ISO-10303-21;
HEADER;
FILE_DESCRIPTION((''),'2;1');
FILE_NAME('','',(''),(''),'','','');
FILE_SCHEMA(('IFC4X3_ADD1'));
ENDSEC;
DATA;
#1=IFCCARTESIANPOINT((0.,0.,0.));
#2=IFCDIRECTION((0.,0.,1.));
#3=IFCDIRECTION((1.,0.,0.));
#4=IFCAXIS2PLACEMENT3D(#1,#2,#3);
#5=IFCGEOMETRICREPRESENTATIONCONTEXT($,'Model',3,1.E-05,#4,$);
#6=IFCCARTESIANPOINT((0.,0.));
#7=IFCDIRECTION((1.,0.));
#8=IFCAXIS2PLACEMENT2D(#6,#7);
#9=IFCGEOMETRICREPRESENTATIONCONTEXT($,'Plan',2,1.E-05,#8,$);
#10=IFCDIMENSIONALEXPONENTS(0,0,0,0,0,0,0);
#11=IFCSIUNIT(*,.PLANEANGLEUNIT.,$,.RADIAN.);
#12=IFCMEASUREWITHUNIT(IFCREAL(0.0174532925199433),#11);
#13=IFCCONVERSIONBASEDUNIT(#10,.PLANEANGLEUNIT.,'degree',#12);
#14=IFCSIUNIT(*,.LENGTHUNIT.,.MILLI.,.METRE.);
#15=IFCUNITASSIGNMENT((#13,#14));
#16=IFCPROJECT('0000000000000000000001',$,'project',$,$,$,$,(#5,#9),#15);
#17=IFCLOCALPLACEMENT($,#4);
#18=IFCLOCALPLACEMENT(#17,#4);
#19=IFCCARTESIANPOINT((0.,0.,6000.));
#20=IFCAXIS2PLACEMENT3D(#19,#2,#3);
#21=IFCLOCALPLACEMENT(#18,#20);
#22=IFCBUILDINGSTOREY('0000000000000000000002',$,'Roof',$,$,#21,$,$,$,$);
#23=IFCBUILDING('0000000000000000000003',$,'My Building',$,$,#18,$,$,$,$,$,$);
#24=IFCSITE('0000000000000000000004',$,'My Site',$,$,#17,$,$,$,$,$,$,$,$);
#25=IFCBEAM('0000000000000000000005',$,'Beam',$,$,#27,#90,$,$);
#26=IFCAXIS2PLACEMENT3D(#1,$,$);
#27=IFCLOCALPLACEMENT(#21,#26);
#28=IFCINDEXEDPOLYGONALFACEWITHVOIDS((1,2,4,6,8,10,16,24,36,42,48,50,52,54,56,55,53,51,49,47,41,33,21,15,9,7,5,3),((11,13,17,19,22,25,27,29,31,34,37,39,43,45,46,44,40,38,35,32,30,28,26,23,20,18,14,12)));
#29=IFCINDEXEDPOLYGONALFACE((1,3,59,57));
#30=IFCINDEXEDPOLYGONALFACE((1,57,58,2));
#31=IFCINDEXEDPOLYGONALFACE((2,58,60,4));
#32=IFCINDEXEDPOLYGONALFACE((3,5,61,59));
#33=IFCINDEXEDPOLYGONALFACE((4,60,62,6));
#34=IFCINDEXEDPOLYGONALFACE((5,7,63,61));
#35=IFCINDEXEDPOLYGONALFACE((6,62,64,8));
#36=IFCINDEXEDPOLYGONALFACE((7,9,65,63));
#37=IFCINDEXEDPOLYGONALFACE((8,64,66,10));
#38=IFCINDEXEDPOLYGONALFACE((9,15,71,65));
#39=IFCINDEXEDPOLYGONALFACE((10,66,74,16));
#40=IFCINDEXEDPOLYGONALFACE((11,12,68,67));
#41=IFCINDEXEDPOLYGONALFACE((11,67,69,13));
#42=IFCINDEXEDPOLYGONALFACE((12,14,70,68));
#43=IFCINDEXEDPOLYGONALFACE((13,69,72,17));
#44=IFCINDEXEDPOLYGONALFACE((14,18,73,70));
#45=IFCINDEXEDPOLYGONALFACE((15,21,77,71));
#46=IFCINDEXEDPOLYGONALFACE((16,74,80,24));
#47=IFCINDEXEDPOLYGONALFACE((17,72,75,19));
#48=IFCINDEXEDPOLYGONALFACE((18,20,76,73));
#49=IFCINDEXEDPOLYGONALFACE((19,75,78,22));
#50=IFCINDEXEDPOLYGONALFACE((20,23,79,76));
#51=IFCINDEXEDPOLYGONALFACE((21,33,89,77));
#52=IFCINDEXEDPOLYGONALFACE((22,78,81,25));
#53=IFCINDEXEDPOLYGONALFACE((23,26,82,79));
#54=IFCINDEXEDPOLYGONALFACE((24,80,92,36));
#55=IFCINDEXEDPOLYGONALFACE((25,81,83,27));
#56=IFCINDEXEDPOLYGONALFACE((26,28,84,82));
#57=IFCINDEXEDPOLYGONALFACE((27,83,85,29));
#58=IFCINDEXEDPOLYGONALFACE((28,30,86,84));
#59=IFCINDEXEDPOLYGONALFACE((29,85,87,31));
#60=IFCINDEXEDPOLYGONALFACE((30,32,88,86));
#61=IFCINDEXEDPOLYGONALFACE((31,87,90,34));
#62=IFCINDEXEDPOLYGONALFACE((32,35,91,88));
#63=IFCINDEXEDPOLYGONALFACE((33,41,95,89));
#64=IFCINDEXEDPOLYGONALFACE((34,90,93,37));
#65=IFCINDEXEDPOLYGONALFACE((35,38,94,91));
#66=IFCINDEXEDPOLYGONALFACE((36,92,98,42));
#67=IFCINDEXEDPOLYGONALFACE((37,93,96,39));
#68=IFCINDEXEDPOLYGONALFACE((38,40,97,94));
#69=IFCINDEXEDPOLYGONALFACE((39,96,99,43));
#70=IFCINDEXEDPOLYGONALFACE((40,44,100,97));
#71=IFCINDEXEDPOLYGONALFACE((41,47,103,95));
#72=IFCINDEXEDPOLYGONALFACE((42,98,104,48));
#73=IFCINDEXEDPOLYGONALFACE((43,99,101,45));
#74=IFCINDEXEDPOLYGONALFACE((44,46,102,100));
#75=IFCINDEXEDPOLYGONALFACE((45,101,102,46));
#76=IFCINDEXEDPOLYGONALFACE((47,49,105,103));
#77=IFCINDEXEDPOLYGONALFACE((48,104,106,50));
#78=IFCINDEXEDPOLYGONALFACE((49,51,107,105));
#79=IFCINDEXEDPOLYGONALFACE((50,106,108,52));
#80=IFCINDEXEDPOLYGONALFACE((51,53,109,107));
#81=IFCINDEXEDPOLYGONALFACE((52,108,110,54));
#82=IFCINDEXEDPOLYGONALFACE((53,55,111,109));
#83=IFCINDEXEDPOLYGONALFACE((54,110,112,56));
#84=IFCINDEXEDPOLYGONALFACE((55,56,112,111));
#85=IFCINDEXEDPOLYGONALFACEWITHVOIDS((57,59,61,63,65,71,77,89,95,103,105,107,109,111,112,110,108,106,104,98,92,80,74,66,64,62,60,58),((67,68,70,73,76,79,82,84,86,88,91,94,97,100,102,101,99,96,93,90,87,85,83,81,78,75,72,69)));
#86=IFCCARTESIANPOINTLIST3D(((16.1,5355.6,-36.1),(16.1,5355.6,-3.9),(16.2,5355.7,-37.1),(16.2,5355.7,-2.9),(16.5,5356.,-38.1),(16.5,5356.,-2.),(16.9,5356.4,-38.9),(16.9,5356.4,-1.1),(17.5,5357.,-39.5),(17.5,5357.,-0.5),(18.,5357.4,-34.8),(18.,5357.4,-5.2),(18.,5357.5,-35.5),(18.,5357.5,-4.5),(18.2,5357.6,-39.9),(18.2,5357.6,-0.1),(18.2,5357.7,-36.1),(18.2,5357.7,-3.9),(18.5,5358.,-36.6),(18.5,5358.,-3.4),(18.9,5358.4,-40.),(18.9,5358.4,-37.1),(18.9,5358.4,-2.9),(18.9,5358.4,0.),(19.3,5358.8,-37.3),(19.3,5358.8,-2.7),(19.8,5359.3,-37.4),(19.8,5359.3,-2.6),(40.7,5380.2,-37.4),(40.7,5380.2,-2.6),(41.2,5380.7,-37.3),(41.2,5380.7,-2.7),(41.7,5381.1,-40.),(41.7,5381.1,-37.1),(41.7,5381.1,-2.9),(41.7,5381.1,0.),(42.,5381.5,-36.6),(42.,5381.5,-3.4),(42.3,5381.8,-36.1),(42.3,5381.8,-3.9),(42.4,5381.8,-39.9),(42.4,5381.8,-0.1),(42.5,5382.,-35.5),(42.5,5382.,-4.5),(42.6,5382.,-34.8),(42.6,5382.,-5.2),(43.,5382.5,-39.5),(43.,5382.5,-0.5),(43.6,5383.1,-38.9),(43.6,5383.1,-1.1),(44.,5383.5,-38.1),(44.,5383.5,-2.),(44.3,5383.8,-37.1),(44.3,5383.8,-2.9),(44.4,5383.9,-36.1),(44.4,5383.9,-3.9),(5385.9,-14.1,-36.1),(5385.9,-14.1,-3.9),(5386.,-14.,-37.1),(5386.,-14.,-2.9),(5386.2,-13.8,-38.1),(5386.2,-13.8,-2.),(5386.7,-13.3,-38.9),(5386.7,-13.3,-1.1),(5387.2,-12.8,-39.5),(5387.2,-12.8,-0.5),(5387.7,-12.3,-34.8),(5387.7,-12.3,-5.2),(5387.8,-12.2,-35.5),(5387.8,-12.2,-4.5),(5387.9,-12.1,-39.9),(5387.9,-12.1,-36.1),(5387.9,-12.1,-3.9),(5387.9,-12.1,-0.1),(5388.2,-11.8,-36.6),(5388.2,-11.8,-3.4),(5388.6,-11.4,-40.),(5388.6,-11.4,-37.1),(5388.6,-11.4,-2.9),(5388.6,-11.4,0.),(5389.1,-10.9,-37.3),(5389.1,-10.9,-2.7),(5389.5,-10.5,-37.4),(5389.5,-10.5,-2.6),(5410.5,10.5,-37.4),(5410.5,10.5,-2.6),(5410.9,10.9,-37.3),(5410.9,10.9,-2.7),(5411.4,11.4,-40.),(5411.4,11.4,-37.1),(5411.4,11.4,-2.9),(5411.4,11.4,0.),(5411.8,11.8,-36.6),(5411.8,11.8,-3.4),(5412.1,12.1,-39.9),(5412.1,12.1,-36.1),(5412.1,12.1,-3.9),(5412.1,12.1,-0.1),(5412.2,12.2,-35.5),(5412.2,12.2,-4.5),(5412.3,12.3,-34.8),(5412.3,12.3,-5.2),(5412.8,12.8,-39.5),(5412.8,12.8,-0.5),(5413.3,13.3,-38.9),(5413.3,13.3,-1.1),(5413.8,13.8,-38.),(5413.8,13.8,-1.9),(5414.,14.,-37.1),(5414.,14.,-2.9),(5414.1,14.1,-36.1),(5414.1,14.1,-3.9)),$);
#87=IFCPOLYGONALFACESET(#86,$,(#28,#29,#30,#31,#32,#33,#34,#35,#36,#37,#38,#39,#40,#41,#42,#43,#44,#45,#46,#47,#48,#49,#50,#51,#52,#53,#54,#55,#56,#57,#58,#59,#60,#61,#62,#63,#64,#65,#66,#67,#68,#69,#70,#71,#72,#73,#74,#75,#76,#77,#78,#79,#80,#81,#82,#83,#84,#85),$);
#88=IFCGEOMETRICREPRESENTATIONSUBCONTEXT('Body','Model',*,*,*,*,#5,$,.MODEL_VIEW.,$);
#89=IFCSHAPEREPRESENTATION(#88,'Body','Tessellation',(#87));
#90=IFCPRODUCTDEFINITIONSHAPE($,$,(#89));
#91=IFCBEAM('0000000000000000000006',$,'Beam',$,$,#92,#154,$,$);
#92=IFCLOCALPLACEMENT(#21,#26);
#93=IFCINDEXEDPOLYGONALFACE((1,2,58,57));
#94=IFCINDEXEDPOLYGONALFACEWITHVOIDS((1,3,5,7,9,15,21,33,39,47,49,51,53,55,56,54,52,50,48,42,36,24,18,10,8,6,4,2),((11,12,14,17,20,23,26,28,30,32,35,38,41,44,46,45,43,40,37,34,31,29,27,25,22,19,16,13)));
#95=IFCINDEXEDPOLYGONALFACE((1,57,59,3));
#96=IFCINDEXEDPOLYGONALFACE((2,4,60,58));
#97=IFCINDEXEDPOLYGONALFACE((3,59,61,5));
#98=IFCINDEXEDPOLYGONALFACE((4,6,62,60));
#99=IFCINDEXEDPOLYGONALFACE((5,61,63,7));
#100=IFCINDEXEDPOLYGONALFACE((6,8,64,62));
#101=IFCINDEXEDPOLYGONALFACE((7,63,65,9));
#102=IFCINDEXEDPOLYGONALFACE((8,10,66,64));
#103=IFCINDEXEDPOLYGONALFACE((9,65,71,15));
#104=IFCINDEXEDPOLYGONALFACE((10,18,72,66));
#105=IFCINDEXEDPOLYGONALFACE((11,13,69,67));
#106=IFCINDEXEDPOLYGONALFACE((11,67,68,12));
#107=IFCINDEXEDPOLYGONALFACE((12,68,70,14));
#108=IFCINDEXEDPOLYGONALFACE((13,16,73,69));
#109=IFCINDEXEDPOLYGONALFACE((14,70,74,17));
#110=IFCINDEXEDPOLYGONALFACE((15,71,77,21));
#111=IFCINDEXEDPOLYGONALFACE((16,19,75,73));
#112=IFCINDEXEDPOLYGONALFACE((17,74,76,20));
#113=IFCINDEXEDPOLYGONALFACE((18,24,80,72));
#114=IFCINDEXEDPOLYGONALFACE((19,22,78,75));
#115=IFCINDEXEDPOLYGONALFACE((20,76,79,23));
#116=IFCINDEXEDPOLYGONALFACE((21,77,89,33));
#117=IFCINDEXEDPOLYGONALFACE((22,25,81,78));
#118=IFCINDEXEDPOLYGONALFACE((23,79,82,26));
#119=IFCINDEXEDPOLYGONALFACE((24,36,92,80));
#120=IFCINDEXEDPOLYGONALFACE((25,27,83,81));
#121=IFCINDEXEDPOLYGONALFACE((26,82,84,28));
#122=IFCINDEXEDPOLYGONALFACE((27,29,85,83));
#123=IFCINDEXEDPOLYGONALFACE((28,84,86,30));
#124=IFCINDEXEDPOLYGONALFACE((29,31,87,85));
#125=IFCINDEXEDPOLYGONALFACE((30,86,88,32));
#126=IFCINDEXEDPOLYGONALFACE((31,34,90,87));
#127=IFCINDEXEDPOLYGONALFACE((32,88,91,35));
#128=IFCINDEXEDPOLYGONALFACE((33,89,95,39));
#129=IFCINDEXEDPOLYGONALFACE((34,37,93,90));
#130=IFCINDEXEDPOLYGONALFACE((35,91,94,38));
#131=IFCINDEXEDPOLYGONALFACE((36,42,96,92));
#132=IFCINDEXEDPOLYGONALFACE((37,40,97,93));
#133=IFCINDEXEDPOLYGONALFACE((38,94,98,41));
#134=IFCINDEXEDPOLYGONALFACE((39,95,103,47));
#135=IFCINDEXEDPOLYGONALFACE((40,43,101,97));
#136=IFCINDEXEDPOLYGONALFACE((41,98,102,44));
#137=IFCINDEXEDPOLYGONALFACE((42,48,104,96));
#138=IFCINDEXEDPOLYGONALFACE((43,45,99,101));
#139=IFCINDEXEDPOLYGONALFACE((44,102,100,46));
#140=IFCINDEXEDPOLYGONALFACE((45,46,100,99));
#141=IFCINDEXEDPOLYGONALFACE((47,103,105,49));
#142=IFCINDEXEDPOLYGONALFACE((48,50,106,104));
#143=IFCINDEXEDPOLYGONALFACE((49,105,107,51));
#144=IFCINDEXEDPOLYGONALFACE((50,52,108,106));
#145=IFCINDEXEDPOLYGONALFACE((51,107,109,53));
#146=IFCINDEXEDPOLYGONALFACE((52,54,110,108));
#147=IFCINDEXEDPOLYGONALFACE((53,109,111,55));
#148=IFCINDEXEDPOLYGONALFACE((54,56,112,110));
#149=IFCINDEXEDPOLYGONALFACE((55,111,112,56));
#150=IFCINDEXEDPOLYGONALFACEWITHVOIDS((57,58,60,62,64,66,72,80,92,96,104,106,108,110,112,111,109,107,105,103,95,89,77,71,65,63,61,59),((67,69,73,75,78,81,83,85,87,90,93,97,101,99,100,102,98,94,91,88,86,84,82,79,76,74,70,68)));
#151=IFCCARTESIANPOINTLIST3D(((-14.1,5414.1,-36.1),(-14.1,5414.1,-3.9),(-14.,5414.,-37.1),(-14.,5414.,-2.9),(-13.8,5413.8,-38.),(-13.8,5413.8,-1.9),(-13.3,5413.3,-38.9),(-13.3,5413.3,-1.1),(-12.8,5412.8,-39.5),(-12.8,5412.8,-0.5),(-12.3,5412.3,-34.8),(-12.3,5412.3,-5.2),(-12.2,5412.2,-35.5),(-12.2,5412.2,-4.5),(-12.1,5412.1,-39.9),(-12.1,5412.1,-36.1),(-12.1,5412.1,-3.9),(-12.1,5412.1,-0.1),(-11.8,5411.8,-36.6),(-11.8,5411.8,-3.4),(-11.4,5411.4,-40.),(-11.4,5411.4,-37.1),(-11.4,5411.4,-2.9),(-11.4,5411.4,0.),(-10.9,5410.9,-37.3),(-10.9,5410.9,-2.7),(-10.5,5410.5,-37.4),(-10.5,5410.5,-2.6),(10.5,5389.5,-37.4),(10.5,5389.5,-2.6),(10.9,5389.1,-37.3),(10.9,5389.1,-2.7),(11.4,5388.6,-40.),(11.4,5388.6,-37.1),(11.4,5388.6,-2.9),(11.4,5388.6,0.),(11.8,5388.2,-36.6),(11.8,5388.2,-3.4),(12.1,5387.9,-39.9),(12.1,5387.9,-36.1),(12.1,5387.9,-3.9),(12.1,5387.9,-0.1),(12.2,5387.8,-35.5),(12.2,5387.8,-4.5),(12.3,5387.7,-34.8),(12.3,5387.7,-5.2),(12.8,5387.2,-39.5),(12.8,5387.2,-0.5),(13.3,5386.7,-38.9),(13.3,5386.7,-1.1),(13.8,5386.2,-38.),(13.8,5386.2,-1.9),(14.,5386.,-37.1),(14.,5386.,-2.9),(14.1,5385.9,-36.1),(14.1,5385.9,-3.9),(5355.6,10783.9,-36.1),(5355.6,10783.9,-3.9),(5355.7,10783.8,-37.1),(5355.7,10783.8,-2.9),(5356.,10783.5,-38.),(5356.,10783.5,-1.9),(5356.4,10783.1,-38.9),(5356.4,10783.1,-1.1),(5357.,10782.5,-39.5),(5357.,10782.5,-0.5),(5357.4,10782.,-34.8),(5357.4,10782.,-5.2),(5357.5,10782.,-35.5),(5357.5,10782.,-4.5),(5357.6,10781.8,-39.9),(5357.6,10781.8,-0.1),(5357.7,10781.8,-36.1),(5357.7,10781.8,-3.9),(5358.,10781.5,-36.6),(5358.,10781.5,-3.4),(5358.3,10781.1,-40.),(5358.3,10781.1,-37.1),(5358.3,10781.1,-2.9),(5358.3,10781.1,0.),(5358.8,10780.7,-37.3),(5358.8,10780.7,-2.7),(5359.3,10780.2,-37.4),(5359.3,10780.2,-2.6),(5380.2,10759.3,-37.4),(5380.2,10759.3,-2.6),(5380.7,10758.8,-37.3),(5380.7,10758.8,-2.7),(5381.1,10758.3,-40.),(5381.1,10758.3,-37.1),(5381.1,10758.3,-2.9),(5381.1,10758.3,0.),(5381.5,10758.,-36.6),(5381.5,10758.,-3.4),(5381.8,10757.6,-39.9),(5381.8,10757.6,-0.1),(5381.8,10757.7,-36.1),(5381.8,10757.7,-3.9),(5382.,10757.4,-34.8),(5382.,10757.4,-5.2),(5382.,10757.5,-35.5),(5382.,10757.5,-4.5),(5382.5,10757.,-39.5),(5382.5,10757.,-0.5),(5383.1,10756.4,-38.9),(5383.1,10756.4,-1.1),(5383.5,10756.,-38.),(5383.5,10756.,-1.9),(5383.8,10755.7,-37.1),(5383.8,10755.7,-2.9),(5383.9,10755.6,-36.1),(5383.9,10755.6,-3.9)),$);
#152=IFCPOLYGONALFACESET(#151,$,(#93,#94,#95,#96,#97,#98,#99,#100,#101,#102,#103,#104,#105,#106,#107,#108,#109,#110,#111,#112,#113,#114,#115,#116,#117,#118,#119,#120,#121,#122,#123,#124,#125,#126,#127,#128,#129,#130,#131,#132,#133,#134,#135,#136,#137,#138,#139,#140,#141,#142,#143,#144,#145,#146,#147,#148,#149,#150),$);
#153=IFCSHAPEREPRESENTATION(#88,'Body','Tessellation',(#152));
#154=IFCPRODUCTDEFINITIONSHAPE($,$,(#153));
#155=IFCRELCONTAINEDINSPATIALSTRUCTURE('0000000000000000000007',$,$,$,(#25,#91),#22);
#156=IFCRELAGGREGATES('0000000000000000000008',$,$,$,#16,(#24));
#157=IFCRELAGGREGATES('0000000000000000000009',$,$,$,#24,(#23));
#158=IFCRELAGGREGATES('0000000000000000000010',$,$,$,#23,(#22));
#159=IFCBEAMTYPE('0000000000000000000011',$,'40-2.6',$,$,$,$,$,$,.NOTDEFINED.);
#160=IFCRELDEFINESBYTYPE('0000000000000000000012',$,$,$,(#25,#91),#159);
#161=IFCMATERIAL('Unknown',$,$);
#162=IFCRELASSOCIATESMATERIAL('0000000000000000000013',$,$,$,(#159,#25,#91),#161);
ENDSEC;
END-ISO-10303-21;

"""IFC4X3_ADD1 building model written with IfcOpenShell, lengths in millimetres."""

from ifc_helpers import new_model, entity, si_unit, converted_unit, frame, origin_with_axes, origin_2d_with_axis, place, context, subcontext, project, spatial, hollow_rectangle, extrude, material, material_profile, profile_set, profile_usage, type_object, element, save


model = new_model("IFC4X3_ADD1")

# Units and contexts
model_context = context("Model", 3, precision=1e-05, world=origin_with_axes())
plan_context = context("Plan", 2, precision=1e-05, world=origin_2d_with_axis())
body_context = subcontext(model_context, "Body", "Model", "MODEL_VIEW")
ifc_project = project(units=[converted_unit("PLANEANGLEUNIT", "degree", entity("IfcReal", 0.0174532925199433), si_unit("PLANEANGLEUNIT", "RADIAN"), dimensions=[0, 0, 0, 0, 0, 0, 0]), si_unit("LENGTHUNIT", "METRE", prefix="MILLI")], contexts=[model_context, plan_context])

# Site, building, storey
site_placement = place(None, origin_with_axes())
site = spatial("IfcSite", under=ifc_project, at=site_placement, Name="My Site")
building_placement = place(site_placement, origin_with_axes())
building = spatial("IfcBuilding", under=site, at=building_placement, Name="My Building")
storey_placement = place(building_placement, frame((0.0, 0.0, 6000.0), z_axis=(0.0, 0.0, 1.0), x_axis=(1.0, 0.0, 0.0)))
storey = spatial("IfcBuildingStorey", under=building, at=storey_placement, Name="Roof")

# Beams
ifc_material = material(Name="Unknown")
ifc_material_profile_1 = material_profile(ifc_material, hollow_rectangle(XDim=40.0, YDim=40.0, WallThickness=2.6, InnerFilletRadius=2.6, OuterFilletRadius=3.9))
ifc_profile_set_1 = profile_set([ifc_material_profile_1])
beam_type_1 = type_object("IfcBeamType", Name="40-2.6", PredefinedType="NOTDEFINED", material=ifc_profile_set_1)
ifc_profile_usage_1 = profile_usage(ifc_profile_set_1, cardinal=8)
beam_1_placement = place(storey_placement, frame((5400.0, 0.0, 0.0), z_axis=(-0.707107, 0.707107, 0.0), x_axis=(-0.707107, -0.707107, 0.0)))
element("IfcBeam", 1, at=beam_1_placement, inside=storey, type_object=beam_type_1, material=ifc_profile_usage_1, Name="Beam", context=body_context, shape_type="SweptSolid", body=[
    extrude(hollow_rectangle(XDim=40.0, YDim=40.0, WallThickness=2.6, InnerFilletRadius=2.6, OuterFilletRadius=3.9), frame((0.0, -20.0, 0.0), z_axis=(0.0, 0.0, 1.0), x_axis=(1.0, 0.0, 0.0)), (0.0, 0.0, 1.0), 7594.0),
])
ifc_profile_usage_2 = profile_usage(ifc_profile_set_1, cardinal=8)
beam_2_placement = place(storey_placement, frame((0.0, 5400.0, 0.0), z_axis=(0.707107, 0.707107, 0.0), x_axis=(-0.707107, 0.707107, 0.0)))
element("IfcBeam", 2, at=beam_2_placement, inside=storey, type_object=beam_type_1, material=ifc_profile_usage_2, Name="Beam", context=body_context, shape_type="SweptSolid", body=[
    extrude(hollow_rectangle(XDim=40.0, YDim=40.0, WallThickness=2.6, InnerFilletRadius=2.6, OuterFilletRadius=3.9), frame((0.0, -20.0, 0.0), z_axis=(0.0, 0.0, 1.0), x_axis=(1.0, 0.0, 0.0)), (0.0, 0.0, 1.0), 7594.0),
])

save(model, "model.ifc")
